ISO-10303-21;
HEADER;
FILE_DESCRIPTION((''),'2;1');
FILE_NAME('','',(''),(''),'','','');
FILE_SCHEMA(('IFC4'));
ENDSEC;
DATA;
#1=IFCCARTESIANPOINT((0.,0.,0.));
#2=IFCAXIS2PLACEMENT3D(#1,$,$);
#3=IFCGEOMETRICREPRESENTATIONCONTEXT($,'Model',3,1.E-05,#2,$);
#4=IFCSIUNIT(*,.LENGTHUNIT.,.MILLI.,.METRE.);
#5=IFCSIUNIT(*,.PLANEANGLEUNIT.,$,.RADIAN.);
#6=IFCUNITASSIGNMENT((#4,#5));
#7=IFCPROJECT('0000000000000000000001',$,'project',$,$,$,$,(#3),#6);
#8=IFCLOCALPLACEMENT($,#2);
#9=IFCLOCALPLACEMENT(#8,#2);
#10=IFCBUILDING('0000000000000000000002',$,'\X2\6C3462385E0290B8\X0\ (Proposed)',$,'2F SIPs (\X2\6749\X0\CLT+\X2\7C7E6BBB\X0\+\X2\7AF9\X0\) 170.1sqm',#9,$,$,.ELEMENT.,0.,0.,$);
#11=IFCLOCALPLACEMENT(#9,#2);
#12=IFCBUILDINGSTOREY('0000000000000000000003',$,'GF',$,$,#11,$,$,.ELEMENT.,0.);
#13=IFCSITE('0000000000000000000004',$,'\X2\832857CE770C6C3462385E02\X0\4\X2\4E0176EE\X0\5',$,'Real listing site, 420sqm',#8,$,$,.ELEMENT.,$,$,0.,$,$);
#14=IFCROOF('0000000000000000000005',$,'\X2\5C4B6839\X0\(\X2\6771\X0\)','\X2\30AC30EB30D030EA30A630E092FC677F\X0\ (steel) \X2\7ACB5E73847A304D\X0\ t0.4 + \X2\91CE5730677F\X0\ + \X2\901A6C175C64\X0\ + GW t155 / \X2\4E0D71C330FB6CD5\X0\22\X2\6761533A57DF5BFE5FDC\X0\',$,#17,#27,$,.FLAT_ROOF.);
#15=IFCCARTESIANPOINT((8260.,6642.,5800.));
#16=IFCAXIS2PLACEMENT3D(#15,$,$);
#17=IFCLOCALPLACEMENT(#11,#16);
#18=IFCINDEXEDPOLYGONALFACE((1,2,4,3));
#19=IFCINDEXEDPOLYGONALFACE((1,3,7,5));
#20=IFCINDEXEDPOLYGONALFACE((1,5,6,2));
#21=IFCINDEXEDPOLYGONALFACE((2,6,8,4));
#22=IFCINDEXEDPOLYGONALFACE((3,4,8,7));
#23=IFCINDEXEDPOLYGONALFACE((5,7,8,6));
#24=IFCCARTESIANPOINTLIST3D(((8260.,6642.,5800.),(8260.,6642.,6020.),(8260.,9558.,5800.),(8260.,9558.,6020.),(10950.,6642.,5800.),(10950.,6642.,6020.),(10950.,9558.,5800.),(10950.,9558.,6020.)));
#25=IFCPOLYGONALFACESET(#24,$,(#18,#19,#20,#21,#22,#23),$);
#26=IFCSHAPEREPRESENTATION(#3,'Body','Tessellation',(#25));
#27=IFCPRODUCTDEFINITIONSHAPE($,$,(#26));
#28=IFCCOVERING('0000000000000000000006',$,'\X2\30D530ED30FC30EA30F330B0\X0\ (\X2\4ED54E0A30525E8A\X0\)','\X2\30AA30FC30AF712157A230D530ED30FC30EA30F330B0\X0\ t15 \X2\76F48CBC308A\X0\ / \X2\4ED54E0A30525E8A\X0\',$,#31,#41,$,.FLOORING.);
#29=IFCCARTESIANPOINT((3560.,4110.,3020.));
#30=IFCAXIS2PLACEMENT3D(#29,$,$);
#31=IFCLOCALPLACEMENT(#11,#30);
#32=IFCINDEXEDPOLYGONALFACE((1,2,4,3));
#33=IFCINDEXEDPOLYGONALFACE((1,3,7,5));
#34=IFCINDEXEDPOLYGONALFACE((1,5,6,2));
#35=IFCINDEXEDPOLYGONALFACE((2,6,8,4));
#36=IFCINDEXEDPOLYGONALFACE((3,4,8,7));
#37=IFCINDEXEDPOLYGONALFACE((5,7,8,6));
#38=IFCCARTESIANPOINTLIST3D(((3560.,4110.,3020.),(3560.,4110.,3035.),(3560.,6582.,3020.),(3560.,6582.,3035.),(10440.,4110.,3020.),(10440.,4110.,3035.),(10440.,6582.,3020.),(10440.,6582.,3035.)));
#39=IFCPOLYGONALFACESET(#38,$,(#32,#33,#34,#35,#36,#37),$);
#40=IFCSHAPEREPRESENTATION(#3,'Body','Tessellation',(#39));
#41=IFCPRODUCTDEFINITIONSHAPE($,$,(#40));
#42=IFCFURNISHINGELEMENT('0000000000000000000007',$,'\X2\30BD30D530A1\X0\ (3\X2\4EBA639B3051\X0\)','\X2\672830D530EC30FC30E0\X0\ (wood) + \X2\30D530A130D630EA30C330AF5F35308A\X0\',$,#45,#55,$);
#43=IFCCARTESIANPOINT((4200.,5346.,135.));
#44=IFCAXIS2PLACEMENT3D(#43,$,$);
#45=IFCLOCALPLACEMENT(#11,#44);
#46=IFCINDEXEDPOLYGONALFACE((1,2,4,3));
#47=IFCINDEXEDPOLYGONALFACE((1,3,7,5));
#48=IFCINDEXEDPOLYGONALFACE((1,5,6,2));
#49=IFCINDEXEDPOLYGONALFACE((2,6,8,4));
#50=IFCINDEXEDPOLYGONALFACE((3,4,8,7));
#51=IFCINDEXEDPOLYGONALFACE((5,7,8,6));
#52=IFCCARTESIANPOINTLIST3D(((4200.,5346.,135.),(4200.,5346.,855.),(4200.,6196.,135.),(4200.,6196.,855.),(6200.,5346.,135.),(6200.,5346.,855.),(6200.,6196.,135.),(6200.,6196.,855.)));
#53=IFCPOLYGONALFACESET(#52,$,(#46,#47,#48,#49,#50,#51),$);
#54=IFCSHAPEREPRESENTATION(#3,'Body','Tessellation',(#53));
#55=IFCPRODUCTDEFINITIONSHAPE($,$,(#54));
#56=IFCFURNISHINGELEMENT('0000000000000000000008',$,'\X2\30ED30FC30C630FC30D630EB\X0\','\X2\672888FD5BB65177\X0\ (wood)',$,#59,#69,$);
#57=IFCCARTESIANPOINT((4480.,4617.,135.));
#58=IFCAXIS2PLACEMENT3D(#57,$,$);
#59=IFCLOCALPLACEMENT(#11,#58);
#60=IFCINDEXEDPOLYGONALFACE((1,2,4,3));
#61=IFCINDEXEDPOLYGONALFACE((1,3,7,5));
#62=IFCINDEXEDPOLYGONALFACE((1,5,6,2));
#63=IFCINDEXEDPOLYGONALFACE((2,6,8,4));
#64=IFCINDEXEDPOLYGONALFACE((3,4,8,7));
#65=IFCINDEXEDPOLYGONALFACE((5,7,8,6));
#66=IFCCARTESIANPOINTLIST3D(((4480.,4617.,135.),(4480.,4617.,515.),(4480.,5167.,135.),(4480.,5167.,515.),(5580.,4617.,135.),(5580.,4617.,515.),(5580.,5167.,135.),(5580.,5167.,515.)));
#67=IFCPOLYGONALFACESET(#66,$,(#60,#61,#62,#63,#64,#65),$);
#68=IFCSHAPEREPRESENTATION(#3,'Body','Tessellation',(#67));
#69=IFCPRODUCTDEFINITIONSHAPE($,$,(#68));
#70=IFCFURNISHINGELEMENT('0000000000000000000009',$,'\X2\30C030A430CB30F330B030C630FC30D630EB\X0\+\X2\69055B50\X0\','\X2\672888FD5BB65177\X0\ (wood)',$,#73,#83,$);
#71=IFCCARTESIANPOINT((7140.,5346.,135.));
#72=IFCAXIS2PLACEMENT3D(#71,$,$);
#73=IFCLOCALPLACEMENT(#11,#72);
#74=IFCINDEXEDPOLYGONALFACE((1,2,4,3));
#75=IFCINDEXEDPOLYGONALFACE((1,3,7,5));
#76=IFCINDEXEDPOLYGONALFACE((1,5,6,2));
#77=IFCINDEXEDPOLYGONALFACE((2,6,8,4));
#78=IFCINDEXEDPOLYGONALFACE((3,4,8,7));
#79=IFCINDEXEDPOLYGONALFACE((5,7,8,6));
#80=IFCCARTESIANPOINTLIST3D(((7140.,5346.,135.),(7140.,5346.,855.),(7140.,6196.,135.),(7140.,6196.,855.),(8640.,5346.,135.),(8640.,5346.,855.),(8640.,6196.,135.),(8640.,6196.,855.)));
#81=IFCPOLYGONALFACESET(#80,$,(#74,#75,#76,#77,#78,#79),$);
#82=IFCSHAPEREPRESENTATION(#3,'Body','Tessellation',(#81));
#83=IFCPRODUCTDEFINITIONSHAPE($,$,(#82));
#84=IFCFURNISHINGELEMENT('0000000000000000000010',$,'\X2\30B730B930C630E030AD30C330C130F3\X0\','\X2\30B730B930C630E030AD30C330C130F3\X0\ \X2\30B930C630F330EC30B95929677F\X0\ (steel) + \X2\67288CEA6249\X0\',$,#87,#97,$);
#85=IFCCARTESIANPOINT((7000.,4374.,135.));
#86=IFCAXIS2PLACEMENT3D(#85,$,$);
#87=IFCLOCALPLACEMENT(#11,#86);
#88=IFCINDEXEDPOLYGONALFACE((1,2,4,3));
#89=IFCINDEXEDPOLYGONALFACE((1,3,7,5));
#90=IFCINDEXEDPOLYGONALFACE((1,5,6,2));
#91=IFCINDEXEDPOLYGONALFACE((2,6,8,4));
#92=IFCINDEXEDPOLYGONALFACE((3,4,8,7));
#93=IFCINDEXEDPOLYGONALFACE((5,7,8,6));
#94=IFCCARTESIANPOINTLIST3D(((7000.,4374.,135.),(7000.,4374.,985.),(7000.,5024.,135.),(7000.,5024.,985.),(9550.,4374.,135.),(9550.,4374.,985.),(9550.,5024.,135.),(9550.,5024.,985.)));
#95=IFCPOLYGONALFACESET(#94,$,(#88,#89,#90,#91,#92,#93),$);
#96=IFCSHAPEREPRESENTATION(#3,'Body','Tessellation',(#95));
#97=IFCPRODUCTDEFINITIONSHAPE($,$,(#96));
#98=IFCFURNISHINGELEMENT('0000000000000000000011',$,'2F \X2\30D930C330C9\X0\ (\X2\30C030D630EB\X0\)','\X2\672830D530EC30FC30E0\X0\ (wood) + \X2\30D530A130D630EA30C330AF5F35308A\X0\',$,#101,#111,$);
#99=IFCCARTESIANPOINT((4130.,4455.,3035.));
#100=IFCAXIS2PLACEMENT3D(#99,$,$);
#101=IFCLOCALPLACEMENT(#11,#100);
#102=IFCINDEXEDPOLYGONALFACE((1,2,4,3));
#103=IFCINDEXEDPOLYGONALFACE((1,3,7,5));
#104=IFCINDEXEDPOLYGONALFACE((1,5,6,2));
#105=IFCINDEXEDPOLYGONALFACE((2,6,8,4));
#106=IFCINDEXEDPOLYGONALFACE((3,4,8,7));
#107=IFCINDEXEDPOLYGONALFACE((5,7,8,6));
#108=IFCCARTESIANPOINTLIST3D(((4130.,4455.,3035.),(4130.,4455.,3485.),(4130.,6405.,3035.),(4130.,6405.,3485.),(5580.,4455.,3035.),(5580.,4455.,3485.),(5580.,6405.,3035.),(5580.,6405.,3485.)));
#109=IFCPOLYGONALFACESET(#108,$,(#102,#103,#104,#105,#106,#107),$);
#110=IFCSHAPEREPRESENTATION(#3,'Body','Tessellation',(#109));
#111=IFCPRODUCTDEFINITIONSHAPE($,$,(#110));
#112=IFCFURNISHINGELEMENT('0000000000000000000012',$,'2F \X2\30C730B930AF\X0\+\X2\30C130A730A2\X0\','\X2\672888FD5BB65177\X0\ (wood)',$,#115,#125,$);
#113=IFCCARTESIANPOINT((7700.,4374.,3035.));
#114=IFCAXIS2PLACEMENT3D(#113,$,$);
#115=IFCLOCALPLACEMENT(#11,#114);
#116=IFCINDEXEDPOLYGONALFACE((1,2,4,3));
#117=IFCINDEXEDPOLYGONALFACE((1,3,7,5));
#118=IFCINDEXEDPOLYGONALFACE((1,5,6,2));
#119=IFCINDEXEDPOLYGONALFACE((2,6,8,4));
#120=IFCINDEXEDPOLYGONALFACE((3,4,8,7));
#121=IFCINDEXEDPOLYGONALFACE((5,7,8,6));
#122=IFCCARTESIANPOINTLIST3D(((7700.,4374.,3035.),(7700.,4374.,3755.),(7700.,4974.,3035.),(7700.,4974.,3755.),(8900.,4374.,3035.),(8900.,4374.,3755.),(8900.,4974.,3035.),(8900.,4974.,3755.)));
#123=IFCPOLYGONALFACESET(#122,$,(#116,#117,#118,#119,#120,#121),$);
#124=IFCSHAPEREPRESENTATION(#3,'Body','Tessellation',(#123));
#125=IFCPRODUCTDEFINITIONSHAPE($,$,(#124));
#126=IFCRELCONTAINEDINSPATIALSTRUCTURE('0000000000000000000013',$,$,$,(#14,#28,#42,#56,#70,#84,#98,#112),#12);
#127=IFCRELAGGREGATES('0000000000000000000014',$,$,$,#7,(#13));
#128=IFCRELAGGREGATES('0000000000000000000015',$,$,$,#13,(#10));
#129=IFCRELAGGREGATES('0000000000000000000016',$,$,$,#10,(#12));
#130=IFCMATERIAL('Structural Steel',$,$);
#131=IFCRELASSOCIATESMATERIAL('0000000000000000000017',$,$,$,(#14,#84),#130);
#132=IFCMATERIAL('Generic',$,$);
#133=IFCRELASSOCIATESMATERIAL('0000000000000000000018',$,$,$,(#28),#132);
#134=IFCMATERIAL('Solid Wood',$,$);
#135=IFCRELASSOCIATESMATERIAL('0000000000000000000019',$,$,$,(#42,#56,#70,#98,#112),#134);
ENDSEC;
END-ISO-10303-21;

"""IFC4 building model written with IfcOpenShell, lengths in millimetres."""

from ifc_helpers import new_model, si_unit, frame, frame_2d, origin, place, context, project, spatial, rectangle, extrude, material, element, save


model = new_model("IFC4")

# Units and contexts
model_context = context("Model", 3, precision=1e-05, world=origin())
ifc_project = project(units=[si_unit("LENGTHUNIT", "METRE", prefix="MILLI"), si_unit("PLANEANGLEUNIT", "RADIAN")], contexts=[model_context])

# Site, building, storey
site_placement = place(None, origin())
site = spatial("IfcSite", under=ifc_project, at=site_placement, Name="茨城県水戸市4丁目5", ObjectType="Real listing site, 420sqm", CompositionType="ELEMENT", RefElevation=0.0)
building_placement = place(site_placement, origin())
building = spatial("IfcBuilding", under=site, at=building_placement, Name="水戸市邸 (Proposed)", ObjectType="2F SIPs (杉CLT+籾殻+竹) 170.1sqm", CompositionType="ELEMENT", ElevationOfRefHeight=0.0, ElevationOfTerrain=0.0)
storey_placement = place(building_placement, origin())
storey = spatial("IfcBuildingStorey", under=building, at=storey_placement, Name="GF", CompositionType="ELEMENT", Elevation=0.0)

# Shared definitions
ifc_material_1 = material(Name="Solid Wood")

# Shared definitions
ifc_material_2 = material(Name="Generic")

# Roof
ifc_material_3 = material(Name="Structural Steel")
roof_placement = place(storey_placement, frame((8260.0, 6642.0, 5800.0)))
element("IfcRoof", 1, at=roof_placement, inside=storey, material=ifc_material_3, Name="屋根(東)", Description="ガルバリウム鋼板 (steel) 立平葺き t0.4 + 野地板 + 通気層 + GW t155 / 不燃・法22条区域対応", PredefinedType="FLAT_ROOF", context=model_context, shape_type="SweptSolid", body=[
    extrude(rectangle(XDim=2690.0, YDim=2916.0, at=frame_2d((1345.0, 1458.0))), frame((8260.0, 6642.0, 5800.0)), (0.0, 0.0, 1.0), 220.0),
])

# Covering
covering_placement = place(storey_placement, frame((3560.0, 4110.0, 3020.0)))
element("IfcCovering", 2, at=covering_placement, inside=storey, material=ifc_material_2, Name="フローリング (仕上げ床)", Description="オーク無垢フローリング t15 直貼り / 仕上げ床", PredefinedType="FLOORING", context=model_context, shape_type="SweptSolid", body=[
    extrude(rectangle(XDim=6880.0, YDim=2472.0, at=frame_2d((3440.0, 1236.0))), frame((3560.0, 4110.0, 3020.0)), (0.0, 0.0, 1.0), 15.0),
])

# Furnishing elements
furnishing_1_placement = place(storey_placement, frame((4200.0, 5346.0, 135.0)))
element("IfcFurnishingElement", 3, at=furnishing_1_placement, inside=storey, material=ifc_material_1, Name="ソファ (3人掛け)", Description="木フレーム (wood) + ファブリック張り", context=model_context, shape_type="SweptSolid", body=[
    extrude(rectangle(XDim=2000.0, YDim=850.0, at=frame_2d((1000.0, 425.0))), frame((4200.0, 5346.0, 135.0)), (0.0, 0.0, 1.0), 720.0),
])
furnishing_2_placement = place(storey_placement, frame((4480.0, 4617.0, 135.0)))
element("IfcFurnishingElement", 4, at=furnishing_2_placement, inside=storey, material=ifc_material_1, Name="ローテーブル", Description="木製家具 (wood)", context=model_context, shape_type="SweptSolid", body=[
    extrude(rectangle(XDim=1100.0, YDim=550.0, at=frame_2d((550.0, 275.0))), frame((4480.0, 4617.0, 135.0)), (0.0, 0.0, 1.0), 380.0),
])
furnishing_3_placement = place(storey_placement, frame((7140.0, 5346.0, 135.0)))
element("IfcFurnishingElement", 5, at=furnishing_3_placement, inside=storey, material=ifc_material_1, Name="ダイニングテーブル+椅子", Description="木製家具 (wood)", context=model_context, shape_type="SweptSolid", body=[
    extrude(rectangle(XDim=1500.0, YDim=850.0, at=frame_2d((750.0, 425.0))), frame((7140.0, 5346.0, 135.0)), (0.0, 0.0, 1.0), 720.0),
])
furnishing_4_placement = place(storey_placement, frame((7000.0, 4374.0, 135.0)))
element("IfcFurnishingElement", 6, at=furnishing_4_placement, inside=storey, material=ifc_material_3, Name="システムキッチン", Description="システムキッチン ステンレス天板 (steel) + 木質扉", context=model_context, shape_type="SweptSolid", body=[
    extrude(rectangle(XDim=2550.0, YDim=650.0, at=frame_2d((1275.0, 325.0))), frame((7000.0, 4374.0, 135.0)), (0.0, 0.0, 1.0), 850.0),
])
furnishing_5_placement = place(storey_placement, frame((4130.0, 4455.0, 3035.0)))
element("IfcFurnishingElement", 7, at=furnishing_5_placement, inside=storey, material=ifc_material_1, Name="2F ベッド (ダブル)", Description="木フレーム (wood) + ファブリック張り", context=model_context, shape_type="SweptSolid", body=[
    extrude(rectangle(XDim=1450.0, YDim=1950.0, at=frame_2d((725.0, 975.0))), frame((4130.0, 4455.0, 3035.0)), (0.0, 0.0, 1.0), 450.0),
])
furnishing_6_placement = place(storey_placement, frame((7700.0, 4374.0, 3035.0)))
element("IfcFurnishingElement", 8, at=furnishing_6_placement, inside=storey, material=ifc_material_1, Name="2F デスク+チェア", Description="木製家具 (wood)", context=model_context, shape_type="SweptSolid", body=[
    extrude(rectangle(XDim=1200.0, YDim=600.0, at=frame_2d((600.0, 300.0))), frame((7700.0, 4374.0, 3035.0)), (0.0, 0.0, 1.0), 720.0),
])

save(model, "model.ifc")
